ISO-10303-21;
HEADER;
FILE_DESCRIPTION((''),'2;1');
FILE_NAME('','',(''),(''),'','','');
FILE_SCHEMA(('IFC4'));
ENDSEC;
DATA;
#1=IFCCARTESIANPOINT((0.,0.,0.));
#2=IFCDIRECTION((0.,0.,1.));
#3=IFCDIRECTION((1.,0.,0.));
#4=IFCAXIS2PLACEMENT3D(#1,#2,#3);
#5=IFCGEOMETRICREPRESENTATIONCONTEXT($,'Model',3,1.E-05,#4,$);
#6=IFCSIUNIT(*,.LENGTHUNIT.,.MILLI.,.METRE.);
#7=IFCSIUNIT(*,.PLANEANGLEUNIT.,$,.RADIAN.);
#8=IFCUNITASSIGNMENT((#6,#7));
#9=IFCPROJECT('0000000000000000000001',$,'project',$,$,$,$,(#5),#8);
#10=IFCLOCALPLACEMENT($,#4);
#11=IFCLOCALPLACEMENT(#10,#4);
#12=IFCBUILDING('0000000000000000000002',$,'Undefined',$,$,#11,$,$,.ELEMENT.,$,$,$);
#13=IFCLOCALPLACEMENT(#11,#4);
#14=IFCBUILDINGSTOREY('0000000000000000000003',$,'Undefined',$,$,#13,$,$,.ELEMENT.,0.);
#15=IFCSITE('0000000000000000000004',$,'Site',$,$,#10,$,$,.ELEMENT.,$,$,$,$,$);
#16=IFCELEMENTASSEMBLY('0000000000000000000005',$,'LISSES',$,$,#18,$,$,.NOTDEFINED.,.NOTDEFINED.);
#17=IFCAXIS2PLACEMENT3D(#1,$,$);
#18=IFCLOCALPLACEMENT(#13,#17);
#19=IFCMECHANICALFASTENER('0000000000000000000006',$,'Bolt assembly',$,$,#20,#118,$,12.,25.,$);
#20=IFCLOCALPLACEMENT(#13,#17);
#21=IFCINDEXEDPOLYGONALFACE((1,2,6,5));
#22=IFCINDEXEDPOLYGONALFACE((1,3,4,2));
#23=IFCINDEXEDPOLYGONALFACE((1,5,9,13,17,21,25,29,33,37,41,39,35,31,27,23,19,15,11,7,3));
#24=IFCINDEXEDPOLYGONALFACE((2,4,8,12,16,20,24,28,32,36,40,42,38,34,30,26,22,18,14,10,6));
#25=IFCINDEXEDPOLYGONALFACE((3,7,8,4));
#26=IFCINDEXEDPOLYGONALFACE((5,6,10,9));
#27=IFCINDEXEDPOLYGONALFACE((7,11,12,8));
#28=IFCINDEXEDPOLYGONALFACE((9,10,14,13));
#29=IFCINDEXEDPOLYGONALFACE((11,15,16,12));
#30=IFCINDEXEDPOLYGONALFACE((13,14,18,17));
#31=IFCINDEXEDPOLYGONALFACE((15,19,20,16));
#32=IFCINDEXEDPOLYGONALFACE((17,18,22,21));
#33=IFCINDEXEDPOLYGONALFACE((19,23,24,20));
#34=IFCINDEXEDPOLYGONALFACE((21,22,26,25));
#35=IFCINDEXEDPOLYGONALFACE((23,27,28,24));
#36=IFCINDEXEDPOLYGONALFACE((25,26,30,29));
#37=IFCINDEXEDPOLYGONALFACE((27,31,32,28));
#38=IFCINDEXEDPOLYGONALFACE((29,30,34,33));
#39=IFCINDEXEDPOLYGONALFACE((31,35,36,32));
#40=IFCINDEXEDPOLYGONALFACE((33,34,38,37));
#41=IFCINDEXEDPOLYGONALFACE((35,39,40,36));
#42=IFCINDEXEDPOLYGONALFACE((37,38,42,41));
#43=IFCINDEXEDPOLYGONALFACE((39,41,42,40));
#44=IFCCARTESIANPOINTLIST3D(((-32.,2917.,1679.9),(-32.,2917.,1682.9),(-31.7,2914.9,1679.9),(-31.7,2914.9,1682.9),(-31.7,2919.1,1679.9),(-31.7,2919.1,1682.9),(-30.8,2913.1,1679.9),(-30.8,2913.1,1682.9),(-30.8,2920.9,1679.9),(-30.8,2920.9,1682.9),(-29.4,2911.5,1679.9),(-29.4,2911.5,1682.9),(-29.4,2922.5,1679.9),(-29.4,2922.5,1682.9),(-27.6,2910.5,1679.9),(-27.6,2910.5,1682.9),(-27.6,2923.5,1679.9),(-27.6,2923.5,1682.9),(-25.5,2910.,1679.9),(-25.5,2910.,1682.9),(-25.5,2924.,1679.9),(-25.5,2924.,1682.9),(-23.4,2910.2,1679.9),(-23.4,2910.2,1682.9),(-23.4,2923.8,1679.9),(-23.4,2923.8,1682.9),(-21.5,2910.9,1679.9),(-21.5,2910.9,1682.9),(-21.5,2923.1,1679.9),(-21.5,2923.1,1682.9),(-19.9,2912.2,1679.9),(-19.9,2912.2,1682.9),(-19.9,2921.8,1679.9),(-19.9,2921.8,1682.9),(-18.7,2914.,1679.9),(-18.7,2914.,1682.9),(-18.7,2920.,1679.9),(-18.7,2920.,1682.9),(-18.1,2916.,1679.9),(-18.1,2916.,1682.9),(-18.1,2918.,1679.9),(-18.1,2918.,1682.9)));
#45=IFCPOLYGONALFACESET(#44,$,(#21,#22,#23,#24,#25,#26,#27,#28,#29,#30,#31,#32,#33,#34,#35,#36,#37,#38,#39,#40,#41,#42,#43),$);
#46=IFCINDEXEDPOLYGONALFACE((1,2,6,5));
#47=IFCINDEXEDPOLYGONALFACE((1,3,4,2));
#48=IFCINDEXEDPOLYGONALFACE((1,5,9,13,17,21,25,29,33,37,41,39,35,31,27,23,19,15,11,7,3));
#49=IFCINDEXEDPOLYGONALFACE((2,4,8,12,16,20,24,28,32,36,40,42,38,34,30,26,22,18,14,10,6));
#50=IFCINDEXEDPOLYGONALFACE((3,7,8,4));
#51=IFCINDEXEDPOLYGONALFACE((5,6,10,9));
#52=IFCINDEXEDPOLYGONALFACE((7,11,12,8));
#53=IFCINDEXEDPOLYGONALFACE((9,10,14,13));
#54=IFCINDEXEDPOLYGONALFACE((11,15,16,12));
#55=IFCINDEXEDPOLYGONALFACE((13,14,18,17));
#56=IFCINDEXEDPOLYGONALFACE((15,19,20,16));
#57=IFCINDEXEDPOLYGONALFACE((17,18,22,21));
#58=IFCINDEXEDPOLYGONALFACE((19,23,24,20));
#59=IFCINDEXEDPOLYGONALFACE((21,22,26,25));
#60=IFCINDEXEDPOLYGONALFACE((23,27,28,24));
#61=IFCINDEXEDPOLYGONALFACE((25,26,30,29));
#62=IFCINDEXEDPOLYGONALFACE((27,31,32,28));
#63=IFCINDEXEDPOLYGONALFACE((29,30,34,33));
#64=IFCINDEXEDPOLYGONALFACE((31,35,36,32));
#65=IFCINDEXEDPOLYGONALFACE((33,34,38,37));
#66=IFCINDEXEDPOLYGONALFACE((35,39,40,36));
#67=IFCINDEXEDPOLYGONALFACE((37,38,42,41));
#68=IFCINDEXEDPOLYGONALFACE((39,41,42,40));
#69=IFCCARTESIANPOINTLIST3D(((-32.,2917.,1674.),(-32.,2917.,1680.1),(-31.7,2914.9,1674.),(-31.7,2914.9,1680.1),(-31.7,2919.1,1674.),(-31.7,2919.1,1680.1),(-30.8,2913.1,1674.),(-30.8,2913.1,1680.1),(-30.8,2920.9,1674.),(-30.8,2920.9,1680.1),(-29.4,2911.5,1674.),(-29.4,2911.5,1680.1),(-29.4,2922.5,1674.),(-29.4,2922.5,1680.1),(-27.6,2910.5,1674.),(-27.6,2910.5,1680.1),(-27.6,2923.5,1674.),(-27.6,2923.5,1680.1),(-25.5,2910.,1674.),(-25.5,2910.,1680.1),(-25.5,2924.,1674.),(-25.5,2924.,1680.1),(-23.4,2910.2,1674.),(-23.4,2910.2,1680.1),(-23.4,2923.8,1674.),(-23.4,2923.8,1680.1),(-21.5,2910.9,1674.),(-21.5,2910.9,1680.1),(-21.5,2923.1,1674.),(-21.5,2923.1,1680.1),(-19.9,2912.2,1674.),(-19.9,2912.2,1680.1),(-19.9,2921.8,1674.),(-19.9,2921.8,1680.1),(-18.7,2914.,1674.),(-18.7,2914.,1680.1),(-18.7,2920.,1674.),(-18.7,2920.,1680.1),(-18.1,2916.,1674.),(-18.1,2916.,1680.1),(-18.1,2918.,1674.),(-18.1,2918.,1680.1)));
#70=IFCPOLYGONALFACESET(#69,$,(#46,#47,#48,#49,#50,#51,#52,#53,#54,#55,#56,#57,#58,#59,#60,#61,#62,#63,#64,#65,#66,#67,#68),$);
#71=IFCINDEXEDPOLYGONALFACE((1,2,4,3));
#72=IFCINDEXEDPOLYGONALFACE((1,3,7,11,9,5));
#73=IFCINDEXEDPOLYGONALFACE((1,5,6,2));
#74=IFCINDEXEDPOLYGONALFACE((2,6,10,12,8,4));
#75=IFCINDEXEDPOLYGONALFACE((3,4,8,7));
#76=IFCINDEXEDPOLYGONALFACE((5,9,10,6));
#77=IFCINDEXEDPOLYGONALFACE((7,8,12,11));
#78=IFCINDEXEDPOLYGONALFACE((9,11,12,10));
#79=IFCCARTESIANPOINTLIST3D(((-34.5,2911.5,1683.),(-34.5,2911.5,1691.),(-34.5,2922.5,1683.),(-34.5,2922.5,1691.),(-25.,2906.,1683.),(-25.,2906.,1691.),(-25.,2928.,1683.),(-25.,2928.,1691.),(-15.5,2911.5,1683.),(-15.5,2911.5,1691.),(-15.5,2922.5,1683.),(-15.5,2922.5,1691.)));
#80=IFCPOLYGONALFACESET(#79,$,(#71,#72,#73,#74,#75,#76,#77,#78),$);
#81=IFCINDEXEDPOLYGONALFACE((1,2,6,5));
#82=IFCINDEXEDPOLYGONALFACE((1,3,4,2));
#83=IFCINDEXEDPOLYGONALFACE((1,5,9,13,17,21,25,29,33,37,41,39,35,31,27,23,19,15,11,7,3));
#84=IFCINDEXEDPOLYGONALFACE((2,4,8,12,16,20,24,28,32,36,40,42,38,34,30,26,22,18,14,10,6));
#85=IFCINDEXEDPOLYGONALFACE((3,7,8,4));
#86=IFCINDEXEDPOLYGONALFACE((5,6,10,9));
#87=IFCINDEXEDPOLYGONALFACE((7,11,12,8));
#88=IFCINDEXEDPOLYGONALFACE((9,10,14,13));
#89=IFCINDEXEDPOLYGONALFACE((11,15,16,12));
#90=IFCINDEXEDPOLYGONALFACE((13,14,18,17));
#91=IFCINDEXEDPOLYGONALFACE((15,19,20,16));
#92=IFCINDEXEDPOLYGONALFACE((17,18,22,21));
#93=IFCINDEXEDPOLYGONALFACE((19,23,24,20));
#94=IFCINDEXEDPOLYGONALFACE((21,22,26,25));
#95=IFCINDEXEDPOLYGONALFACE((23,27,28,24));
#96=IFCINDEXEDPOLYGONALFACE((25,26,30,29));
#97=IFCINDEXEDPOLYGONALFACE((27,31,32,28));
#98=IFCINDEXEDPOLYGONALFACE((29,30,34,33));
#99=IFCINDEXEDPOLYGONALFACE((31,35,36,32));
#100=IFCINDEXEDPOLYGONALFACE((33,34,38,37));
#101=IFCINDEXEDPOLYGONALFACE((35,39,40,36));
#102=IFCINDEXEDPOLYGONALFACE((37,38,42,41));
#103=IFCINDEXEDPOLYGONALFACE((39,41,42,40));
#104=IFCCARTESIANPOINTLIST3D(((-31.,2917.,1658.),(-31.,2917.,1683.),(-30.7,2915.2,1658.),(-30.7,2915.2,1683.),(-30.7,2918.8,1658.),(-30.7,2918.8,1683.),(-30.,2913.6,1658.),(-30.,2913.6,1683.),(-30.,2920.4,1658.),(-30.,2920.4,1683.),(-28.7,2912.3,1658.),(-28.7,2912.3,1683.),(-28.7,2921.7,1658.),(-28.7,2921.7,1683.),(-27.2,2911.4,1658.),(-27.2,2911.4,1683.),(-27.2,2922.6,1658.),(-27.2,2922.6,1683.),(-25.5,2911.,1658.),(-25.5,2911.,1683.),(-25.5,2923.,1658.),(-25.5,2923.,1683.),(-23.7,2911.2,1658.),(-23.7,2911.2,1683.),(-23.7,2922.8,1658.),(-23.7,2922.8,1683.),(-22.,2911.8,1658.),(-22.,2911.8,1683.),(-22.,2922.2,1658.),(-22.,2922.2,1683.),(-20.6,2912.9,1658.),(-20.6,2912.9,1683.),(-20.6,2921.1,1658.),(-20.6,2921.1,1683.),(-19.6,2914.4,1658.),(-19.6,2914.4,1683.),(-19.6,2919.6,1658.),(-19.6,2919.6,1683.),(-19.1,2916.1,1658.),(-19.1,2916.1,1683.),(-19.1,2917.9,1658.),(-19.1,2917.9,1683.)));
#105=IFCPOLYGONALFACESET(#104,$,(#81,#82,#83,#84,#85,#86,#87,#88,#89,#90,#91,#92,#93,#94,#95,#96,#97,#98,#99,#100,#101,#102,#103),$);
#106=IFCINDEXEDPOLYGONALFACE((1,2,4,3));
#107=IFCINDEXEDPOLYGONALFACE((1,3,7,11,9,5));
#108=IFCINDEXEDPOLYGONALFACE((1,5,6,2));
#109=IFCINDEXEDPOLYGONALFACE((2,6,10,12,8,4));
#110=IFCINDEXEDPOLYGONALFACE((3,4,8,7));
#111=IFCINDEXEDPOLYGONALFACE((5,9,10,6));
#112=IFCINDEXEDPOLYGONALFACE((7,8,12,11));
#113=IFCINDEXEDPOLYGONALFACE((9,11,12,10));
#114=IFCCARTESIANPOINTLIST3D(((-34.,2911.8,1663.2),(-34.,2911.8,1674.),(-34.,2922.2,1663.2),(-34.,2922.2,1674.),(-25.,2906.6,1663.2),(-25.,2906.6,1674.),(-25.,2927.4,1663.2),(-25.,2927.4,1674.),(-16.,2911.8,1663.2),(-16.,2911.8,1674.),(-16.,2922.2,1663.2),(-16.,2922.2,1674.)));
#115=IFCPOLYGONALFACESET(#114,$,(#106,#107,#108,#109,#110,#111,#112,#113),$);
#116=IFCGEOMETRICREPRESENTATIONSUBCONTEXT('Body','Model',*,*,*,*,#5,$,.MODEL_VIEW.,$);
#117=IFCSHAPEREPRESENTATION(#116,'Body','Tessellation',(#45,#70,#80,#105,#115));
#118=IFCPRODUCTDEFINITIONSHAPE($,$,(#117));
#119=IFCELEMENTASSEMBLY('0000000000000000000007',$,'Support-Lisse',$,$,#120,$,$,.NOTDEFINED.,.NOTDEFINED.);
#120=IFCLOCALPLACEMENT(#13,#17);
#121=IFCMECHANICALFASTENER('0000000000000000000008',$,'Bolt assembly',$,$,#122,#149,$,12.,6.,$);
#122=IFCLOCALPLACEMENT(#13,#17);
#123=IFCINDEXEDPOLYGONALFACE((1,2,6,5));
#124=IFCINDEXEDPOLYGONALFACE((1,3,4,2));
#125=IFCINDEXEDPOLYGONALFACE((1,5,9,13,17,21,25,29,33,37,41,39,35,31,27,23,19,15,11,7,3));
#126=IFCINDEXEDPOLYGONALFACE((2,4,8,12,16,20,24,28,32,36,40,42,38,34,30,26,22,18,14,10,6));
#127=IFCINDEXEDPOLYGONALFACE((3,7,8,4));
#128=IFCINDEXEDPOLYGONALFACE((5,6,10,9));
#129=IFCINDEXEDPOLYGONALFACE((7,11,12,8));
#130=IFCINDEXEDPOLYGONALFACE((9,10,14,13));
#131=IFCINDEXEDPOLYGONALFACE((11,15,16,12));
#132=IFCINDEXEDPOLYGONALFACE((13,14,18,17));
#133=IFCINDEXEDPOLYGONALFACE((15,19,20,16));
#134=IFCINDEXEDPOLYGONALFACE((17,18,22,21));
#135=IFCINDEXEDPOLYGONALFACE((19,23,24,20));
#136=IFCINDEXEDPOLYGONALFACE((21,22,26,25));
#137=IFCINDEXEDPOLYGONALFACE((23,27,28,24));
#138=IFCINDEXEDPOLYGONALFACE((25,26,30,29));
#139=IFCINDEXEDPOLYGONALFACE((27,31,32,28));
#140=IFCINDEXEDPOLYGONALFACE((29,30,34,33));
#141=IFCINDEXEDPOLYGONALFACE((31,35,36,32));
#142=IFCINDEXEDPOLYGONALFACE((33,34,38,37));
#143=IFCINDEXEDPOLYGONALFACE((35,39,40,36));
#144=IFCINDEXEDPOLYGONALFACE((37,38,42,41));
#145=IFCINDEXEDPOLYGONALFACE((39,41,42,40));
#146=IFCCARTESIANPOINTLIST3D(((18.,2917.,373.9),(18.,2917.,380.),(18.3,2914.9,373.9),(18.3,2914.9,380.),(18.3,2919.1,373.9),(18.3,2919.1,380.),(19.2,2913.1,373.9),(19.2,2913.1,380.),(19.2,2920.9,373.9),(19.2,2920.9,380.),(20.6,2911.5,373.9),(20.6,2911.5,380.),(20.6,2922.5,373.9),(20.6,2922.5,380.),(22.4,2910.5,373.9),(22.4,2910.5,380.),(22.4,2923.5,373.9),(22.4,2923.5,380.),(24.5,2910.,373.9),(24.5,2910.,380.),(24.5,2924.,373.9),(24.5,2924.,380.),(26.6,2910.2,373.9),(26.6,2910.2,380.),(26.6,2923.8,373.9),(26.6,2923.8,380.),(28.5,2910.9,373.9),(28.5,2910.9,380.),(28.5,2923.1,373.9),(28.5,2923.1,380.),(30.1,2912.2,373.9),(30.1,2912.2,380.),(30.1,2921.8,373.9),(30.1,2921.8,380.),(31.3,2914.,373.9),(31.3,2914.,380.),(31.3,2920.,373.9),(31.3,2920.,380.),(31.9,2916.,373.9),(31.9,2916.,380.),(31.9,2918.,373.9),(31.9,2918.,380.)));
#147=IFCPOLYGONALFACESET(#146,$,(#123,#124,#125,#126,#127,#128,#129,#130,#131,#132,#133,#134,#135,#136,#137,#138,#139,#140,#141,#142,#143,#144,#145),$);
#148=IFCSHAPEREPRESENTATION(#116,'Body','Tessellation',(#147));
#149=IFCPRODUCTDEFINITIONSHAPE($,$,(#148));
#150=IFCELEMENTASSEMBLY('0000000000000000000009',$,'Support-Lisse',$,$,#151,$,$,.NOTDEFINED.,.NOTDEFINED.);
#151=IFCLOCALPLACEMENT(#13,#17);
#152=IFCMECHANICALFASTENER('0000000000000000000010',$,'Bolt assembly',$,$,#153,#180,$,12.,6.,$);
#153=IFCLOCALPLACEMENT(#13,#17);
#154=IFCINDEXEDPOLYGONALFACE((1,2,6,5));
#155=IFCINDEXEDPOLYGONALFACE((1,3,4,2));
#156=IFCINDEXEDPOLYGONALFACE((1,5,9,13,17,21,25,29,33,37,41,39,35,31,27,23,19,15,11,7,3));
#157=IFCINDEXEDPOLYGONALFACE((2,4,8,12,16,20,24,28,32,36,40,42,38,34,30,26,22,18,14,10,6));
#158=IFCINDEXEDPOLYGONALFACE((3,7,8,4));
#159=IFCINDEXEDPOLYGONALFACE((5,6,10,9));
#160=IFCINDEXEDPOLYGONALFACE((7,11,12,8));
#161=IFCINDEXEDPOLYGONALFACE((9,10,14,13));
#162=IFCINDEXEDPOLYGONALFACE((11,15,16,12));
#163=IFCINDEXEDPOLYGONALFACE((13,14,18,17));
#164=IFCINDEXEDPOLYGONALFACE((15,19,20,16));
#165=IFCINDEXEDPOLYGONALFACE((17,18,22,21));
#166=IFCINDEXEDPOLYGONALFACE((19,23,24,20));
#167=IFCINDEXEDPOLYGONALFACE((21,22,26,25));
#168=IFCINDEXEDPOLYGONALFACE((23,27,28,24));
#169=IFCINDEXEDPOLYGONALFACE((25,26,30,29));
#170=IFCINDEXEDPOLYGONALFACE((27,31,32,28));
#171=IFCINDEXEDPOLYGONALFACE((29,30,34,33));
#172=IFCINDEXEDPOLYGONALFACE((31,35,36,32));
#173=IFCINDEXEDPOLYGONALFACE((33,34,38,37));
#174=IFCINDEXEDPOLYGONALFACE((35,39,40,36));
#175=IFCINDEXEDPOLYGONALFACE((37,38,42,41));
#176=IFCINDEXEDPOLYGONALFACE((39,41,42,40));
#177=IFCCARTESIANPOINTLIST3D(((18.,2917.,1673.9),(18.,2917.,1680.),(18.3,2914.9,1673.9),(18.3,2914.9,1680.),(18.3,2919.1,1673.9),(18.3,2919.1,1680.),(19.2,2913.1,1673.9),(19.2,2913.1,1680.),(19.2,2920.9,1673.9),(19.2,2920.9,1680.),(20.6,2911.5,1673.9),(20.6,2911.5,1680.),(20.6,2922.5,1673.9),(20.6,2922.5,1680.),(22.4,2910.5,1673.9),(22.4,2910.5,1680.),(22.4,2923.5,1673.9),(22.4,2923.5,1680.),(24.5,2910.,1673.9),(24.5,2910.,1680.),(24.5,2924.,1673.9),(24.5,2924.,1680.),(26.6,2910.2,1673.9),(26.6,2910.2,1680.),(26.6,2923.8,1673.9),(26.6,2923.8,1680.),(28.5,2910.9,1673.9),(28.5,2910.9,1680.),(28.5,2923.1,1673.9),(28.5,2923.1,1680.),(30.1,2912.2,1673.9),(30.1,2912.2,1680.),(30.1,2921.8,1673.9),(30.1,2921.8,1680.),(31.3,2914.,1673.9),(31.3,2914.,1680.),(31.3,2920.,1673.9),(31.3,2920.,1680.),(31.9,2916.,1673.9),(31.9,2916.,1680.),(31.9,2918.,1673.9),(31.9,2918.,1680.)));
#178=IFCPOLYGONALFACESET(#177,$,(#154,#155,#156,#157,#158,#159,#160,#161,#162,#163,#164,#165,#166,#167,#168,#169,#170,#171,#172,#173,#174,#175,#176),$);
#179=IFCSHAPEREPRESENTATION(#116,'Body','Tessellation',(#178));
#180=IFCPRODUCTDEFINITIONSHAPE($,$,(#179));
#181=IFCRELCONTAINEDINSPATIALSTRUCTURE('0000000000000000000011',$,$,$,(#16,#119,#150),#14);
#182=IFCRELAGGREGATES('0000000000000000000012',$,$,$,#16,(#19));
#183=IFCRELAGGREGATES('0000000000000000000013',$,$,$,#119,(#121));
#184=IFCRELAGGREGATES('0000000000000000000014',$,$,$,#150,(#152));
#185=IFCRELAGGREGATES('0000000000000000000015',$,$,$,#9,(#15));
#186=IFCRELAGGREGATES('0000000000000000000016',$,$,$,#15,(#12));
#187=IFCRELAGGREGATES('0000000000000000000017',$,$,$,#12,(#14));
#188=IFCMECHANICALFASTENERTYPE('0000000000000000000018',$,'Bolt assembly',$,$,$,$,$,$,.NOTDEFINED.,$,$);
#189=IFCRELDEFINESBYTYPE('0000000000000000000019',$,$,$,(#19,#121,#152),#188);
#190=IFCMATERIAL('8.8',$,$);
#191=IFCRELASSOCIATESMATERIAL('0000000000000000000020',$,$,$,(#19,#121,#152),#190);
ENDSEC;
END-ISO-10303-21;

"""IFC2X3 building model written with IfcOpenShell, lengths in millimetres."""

from ifc_helpers import new_model, si_unit, frame, origin_with_axes, origin_2d_with_axis, place, context, subcontext, project, spatial, polyline, circle, outline, extrude, source, transform, mapped, material, type_object, element, aggregate, save


model = new_model("IFC2X3")

# Units and contexts
model_context = context("Model", 3, precision=1e-05, world=origin_with_axes())
body_context = subcontext(model_context, "Body", "Model", "MODEL_VIEW")
ifc_project = project(units=[si_unit("LENGTHUNIT", "METRE", prefix="MILLI"), si_unit("PLANEANGLEUNIT", "RADIAN")], contexts=[model_context])

# Site, building, storey
site_placement = place(None, origin_with_axes())
site = spatial("IfcSite", under=ifc_project, at=site_placement, Name="Site", CompositionType="ELEMENT")
building_placement = place(site_placement, origin_with_axes())
building = spatial("IfcBuilding", under=site, at=building_placement, Name="Undefined", CompositionType="ELEMENT")
storey_placement = place(building_placement, origin_with_axes())
storey = spatial("IfcBuildingStorey", under=building, at=storey_placement, Name="Undefined", CompositionType="ELEMENT", Elevation=0.0)

# Element assembly
assembly_1_placement = place(storey_placement, origin_with_axes())
assembly_1 = element("IfcElementAssembly", 1, at=assembly_1_placement, inside=storey, Name="LISSES", AssemblyPlace="NOTDEFINED", PredefinedType="NOTDEFINED")

# Mechanical fastener
mechanical_fastener_type = type_object("IfcMechanicalFastenerType", Name="Bolt assembly")
ifc_material_1 = material(Name="8.8")
shared_shape_1 = source(origin_with_axes(), body_context, "Body", "SweptSolid", [
    extrude(circle(Radius=7.0, at=origin_2d_with_axis()), frame((0.0, -5.9, 0.0), z_axis=(0.0, 1.0, 0.0), x_axis=(1.0, 0.0, 0.0)), (0.0, 0.0, 1.0), 3.0),
    extrude(circle(Radius=7.0, at=origin_2d_with_axis()), frame((0.0, -3.1, 0.0), z_axis=(0.0, 1.0, 0.0), x_axis=(1.0, 0.0, 0.0)), (0.0, 0.0, 1.0), 6.1),
    extrude(outline(polyline([(9.5, -5.5), (9.5, 5.5), (0.0, 11.0), (-9.5, 5.5), (-9.5, -5.5), (0.0, -11.0), (9.5, -5.5)])), frame((0.0, -14.0, 0.0), z_axis=(0.0, 1.0, 0.0), x_axis=(1.0, 0.0, 0.0)), (0.0, 0.0, 1.0), 8.0),
    extrude(circle(Radius=6.0, at=origin_2d_with_axis()), frame((0.0, -6.0, 0.0), z_axis=(0.0, 1.0, 0.0), x_axis=(1.0, 0.0, 0.0)), (0.0, 0.0, 1.0), 25.0),
    extrude(outline(polyline([(9.0, -5.2), (9.0, 5.2), (0.0, 10.4), (-9.0, 5.2), (-9.0, -5.2), (0.0, -10.4), (9.0, -5.2)])), frame((0.0, 3.0, 0.0), z_axis=(0.0, 1.0, 0.0), x_axis=(1.0, 0.0, 0.0)), (0.0, 0.0, 1.0), 10.8),
])
mechanical_fastener_1_placement = place(assembly_1_placement, frame((-25.0, 2917.0, 1677.0), z_axis=(0.0, -1.0, 0.0), x_axis=(-1.0, 0.0, 0.0)))
mechanical_fastener_1 = element("IfcMechanicalFastener", 2, at=mechanical_fastener_1_placement, type_object=mechanical_fastener_type, material=ifc_material_1, Name="Bolt assembly", NominalDiameter=12.0, NominalLength=25.0, context=body_context, shape_type="MappedRepresentation", body=[
    mapped(shared_shape_1, transform((0.0, 0.0, 0.0))),
])
aggregate(assembly_1, [mechanical_fastener_1])

# Element assemblies, mechanical fasteners
assembly_2_placement = place(storey_placement, origin_with_axes())
assembly_2 = element("IfcElementAssembly", 3, at=assembly_2_placement, inside=storey, Name="Support-Lisse", AssemblyPlace="NOTDEFINED", PredefinedType="NOTDEFINED")
shared_shape_2 = source(origin_with_axes(), body_context, "Body", "SweptSolid", [
    extrude(circle(Radius=7.0, at=origin_2d_with_axis()), frame((0.0, 0.0, 0.0), z_axis=(0.0, 1.0, 0.0), x_axis=(1.0, 0.0, 0.0)), (0.0, 0.0, 1.0), 6.1),
])
mechanical_fastener_2_placement = place(assembly_2_placement, frame((25.0, 2917.0, 380.0), z_axis=(0.0, -1.0, 0.0), x_axis=(-1.0, 0.0, 0.0)))
mechanical_fastener_2 = element("IfcMechanicalFastener", 4, at=mechanical_fastener_2_placement, type_object=mechanical_fastener_type, material=ifc_material_1, Name="Bolt assembly", NominalDiameter=12.0, NominalLength=6.0, context=body_context, shape_type="MappedRepresentation", body=[
    mapped(shared_shape_2, transform((0.0, 0.0, 0.0))),
])
assembly_3_placement = place(storey_placement, origin_with_axes())
assembly_3 = element("IfcElementAssembly", 5, at=assembly_3_placement, inside=storey, Name="Support-Lisse", AssemblyPlace="NOTDEFINED", PredefinedType="NOTDEFINED")
mechanical_fastener_3_placement = place(assembly_3_placement, frame((25.0, 2917.0, 1680.0), z_axis=(0.0, -1.0, 0.0), x_axis=(-1.0, 0.0, 0.0)))
mechanical_fastener_3 = element("IfcMechanicalFastener", 6, at=mechanical_fastener_3_placement, type_object=mechanical_fastener_type, material=ifc_material_1, Name="Bolt assembly", NominalDiameter=12.0, NominalLength=6.0, context=body_context, shape_type="MappedRepresentation", body=[
    mapped(shared_shape_2, transform((0.0, 0.0, 0.0))),
])

aggregate(assembly_2, [mechanical_fastener_2])
aggregate(assembly_3, [mechanical_fastener_3])

save(model, "model.ifc")
